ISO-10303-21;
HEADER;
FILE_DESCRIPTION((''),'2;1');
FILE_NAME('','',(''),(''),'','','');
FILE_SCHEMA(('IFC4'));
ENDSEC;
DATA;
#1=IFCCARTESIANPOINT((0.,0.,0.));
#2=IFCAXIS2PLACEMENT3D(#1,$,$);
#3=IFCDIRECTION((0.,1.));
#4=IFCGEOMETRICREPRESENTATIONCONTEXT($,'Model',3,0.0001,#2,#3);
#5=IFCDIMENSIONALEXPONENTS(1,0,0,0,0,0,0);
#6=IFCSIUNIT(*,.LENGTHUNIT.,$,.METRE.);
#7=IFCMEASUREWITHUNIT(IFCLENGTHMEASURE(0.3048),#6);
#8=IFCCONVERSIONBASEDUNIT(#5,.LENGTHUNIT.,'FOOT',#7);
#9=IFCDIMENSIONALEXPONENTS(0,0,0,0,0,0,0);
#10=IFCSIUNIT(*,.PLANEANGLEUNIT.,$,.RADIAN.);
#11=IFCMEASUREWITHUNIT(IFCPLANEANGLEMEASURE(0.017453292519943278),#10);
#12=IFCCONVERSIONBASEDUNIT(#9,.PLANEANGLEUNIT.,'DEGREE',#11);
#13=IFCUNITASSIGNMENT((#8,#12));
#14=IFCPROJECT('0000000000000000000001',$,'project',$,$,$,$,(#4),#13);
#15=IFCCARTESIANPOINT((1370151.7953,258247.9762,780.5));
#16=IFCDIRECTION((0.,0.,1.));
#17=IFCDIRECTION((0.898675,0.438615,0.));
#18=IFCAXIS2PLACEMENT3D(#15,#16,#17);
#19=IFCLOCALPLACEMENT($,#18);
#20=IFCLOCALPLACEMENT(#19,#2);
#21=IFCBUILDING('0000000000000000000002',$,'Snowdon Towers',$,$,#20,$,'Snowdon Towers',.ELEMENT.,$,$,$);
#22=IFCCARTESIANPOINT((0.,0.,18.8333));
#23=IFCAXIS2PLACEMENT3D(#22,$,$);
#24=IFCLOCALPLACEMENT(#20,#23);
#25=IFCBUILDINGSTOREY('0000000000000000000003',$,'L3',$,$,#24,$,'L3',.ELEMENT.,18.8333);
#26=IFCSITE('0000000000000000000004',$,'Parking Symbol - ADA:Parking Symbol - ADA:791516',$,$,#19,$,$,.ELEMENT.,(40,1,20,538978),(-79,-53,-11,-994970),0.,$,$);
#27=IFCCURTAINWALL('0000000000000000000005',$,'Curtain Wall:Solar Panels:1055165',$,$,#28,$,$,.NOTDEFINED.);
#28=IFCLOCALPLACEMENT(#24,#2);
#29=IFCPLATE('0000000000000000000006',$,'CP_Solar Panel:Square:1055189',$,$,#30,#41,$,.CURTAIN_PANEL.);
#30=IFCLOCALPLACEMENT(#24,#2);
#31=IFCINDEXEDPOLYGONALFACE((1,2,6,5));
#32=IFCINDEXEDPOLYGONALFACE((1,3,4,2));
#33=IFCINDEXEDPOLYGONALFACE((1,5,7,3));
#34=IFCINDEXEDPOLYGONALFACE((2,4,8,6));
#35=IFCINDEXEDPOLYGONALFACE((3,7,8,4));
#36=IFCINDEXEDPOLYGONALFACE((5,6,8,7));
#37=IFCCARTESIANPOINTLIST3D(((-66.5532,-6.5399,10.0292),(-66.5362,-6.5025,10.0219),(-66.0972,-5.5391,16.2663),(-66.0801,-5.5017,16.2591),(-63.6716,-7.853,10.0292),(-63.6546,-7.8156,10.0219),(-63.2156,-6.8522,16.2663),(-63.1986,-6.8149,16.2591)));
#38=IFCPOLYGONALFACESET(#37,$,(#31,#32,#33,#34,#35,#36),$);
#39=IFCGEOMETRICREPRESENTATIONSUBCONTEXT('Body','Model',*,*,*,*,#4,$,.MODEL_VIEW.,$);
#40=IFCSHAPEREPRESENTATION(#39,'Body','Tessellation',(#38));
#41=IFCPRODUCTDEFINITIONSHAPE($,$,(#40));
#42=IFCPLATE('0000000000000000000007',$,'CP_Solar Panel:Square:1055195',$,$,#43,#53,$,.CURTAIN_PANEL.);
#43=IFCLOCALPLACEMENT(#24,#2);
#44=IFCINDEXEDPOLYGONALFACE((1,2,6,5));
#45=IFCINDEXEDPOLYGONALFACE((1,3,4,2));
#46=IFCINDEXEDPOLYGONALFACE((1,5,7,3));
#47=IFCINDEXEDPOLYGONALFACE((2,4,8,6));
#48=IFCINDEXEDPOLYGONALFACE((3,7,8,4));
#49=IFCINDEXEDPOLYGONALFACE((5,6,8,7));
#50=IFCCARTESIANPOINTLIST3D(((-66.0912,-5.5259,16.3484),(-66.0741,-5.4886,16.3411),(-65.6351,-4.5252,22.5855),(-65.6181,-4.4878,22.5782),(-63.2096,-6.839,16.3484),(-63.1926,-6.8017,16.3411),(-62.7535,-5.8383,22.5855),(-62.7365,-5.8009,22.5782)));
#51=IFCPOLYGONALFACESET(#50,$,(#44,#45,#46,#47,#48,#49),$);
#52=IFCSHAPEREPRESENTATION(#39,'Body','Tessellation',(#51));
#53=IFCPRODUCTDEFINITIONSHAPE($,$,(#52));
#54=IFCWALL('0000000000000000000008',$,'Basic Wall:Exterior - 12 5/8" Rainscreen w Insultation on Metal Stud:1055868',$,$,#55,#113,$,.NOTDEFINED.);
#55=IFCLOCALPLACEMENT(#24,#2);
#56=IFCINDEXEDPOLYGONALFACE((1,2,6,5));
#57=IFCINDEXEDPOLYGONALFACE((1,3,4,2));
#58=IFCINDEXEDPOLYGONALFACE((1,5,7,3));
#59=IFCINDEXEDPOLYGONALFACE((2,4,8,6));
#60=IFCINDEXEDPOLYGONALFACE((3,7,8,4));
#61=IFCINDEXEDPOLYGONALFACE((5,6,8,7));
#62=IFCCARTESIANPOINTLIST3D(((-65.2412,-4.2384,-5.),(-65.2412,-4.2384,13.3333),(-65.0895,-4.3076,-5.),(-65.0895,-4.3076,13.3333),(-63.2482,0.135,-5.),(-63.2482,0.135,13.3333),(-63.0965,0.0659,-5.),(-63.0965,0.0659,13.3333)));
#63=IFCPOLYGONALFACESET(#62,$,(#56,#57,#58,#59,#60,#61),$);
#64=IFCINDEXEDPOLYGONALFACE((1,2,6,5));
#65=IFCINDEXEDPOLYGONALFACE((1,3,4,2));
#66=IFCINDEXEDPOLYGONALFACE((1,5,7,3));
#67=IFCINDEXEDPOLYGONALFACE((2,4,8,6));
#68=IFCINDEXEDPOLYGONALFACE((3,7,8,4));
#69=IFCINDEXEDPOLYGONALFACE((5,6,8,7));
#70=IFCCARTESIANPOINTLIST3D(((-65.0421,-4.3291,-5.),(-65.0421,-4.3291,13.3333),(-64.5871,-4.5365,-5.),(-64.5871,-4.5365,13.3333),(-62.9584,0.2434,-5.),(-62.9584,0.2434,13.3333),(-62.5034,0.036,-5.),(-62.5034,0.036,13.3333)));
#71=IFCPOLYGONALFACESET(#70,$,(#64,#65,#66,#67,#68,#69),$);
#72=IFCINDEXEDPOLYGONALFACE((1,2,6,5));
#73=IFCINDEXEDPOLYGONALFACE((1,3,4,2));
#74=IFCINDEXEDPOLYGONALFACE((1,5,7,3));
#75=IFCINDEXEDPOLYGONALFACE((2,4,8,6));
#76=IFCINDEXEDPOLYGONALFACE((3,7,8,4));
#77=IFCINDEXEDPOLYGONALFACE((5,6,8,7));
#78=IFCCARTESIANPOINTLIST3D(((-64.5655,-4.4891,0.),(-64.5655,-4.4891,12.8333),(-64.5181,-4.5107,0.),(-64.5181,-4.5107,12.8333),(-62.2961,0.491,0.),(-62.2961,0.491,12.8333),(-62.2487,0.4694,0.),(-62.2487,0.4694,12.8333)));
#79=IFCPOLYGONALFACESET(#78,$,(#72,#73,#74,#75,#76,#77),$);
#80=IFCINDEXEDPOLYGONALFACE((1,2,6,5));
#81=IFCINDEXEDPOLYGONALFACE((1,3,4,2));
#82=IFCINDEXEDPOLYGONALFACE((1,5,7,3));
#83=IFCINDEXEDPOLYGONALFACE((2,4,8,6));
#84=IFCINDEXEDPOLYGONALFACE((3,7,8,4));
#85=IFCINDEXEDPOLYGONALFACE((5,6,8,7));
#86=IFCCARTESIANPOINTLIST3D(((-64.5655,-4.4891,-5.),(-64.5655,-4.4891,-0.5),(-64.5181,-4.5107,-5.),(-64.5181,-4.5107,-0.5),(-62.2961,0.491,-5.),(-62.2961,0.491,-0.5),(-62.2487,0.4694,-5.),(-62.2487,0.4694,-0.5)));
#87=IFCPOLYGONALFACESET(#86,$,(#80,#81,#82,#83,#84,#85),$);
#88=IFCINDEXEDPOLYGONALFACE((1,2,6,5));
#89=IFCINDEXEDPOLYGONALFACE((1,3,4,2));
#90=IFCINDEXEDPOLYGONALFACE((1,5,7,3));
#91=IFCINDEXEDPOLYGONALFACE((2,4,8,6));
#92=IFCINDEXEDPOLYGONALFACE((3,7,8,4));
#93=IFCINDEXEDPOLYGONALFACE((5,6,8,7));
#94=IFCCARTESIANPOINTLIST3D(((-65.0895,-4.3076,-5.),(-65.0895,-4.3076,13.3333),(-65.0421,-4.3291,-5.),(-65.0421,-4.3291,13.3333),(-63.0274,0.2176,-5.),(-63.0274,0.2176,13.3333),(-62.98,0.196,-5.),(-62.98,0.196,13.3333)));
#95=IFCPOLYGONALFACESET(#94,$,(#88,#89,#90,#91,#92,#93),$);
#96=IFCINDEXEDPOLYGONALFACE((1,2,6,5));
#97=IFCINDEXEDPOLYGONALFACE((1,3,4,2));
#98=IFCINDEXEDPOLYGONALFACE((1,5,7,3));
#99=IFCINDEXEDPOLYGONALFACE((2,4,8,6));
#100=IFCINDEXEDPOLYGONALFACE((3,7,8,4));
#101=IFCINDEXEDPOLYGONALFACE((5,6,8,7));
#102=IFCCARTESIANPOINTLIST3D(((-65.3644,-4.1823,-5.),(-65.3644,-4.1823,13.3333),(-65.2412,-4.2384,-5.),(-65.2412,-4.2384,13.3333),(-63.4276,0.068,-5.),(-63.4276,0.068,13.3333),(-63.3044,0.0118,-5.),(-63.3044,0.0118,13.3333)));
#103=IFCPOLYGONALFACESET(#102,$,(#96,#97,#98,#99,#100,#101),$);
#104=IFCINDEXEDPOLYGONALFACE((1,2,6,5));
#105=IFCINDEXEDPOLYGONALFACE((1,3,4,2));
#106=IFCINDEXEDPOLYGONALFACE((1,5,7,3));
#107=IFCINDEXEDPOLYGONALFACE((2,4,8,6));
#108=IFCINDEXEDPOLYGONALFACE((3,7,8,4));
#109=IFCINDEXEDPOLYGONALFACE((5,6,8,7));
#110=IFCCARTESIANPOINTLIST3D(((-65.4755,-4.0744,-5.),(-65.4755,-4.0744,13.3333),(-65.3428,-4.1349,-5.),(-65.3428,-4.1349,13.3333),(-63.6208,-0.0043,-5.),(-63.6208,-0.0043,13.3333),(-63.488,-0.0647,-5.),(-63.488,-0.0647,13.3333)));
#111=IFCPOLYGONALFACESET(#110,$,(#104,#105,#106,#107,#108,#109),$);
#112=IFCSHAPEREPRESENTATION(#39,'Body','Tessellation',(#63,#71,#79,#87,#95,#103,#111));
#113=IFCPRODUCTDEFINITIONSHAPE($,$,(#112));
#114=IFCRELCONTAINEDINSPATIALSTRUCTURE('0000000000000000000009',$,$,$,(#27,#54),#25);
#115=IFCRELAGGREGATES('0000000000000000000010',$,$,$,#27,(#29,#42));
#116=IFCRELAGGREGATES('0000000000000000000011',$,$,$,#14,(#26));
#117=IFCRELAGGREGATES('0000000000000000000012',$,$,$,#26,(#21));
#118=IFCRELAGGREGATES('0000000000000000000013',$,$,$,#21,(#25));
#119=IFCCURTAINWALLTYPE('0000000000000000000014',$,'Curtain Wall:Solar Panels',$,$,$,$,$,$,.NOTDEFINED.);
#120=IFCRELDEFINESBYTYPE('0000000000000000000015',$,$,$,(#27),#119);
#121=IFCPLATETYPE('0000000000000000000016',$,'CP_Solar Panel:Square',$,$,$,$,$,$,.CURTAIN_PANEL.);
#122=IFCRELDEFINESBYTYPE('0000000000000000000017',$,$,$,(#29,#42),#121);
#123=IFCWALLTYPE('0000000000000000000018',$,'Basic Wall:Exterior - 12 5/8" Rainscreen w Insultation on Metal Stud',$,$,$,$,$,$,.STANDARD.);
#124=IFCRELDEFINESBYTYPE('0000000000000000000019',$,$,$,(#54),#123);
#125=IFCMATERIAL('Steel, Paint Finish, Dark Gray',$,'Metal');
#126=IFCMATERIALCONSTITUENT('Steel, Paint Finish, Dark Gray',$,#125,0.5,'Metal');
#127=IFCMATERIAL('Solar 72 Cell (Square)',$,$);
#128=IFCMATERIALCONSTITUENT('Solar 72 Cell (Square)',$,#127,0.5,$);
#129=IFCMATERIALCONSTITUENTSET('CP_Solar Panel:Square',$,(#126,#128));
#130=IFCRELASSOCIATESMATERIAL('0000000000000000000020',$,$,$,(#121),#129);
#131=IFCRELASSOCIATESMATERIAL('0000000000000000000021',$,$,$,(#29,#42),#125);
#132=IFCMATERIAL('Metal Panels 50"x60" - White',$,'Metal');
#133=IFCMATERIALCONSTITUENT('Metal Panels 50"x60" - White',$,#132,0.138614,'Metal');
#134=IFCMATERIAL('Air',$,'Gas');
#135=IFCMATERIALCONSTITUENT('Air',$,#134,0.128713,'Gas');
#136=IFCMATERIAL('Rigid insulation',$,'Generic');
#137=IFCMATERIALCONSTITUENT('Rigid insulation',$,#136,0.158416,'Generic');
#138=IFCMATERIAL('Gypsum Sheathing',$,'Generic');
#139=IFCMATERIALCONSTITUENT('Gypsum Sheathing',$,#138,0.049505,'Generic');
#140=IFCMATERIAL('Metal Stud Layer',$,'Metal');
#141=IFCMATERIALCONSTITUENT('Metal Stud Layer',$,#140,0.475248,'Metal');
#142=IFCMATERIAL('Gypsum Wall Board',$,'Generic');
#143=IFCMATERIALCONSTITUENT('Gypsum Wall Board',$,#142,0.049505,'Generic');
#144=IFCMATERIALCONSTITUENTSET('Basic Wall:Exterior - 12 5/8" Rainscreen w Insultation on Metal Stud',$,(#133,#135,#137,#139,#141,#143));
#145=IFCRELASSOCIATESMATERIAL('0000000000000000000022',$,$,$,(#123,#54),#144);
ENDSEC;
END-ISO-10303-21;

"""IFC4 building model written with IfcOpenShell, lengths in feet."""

from ifc_helpers import new_model, entity, si_unit, converted_unit, direction, frame, origin, place, context, subcontext, project, spatial, indexed_curve, outline, extrude, source, transform, mapped, material, constituent, constituent_set, type_object, type_shapes, element, aggregate, save


model = new_model("IFC4")

# Units and contexts
model_context = context("Model", 3, precision=0.0001, world=origin(), true_north=direction((0.0, 1.0)))
body_context = subcontext(model_context, "Body", "Model", "MODEL_VIEW")
ifc_project = project(units=[converted_unit("LENGTHUNIT", "FOOT", entity("IfcLengthMeasure", 0.3048), si_unit("LENGTHUNIT", "METRE"), dimensions=[1, 0, 0, 0, 0, 0, 0]), converted_unit("PLANEANGLEUNIT", "DEGREE", entity("IfcPlaneAngleMeasure", 0.017453292519943278), si_unit("PLANEANGLEUNIT", "RADIAN"), dimensions=[0, 0, 0, 0, 0, 0, 0])], contexts=[model_context])

# Site, building, storey
site_placement = place(None, frame((1370151.7953, 258247.9762, 780.5), z_axis=(0.0, 0.0, 1.0), x_axis=(0.898675, 0.438615, 0.0)))
site = spatial("IfcSite", under=ifc_project, at=site_placement, Name="Parking Symbol - ADA:Parking Symbol - ADA:791516", CompositionType="ELEMENT", RefLatitude=(40, 1, 20, 538978), RefLongitude=(-79, -53, -11, -994970), RefElevation=0.0)
building_placement = place(site_placement, origin())
building = spatial("IfcBuilding", under=site, at=building_placement, Name="Snowdon Towers", LongName="Snowdon Towers", CompositionType="ELEMENT")
storey_placement = place(building_placement, frame((0.0, 0.0, 18.8333)))
storey = spatial("IfcBuildingStorey", under=building, at=storey_placement, Name="L3", LongName="L3", CompositionType="ELEMENT", Elevation=18.8333)

# Curtain wall
curtain_wall_type_1 = type_object("IfcCurtainWallType", Name="Curtain Wall:Solar Panels", PredefinedType="NOTDEFINED")
curtain_wall_1_placement = place(storey_placement, frame((0.0, 0.0, -18.8333)))
curtain_wall_1 = element("IfcCurtainWall", 1, at=curtain_wall_1_placement, inside=storey, type_object=curtain_wall_type_1, Name="Curtain Wall:Solar Panels:1055165", PredefinedType="NOTDEFINED")
ifc_material_1 = material(Name="Steel, Paint Finish, Dark Gray", Category="Metal")

# Plates
ifc_constituent_1 = constituent(ifc_material_1, Name="Steel, Paint Finish, Dark Gray", Category="Metal", fraction=0.5)
ifc_material_2 = material(Name="Solar 72 Cell (Square)")
ifc_constituent_2 = constituent(ifc_material_2, Name="Solar 72 Cell (Square)", fraction=0.5)
ifc_constituent_set_1 = constituent_set(constituents=[ifc_constituent_1, ifc_constituent_2], Name="CP_Solar Panel:Square")
plate_type_1 = type_object("IfcPlateType", Name="CP_Solar Panel:Square", PredefinedType="CURTAIN_PANEL", material=ifc_constituent_set_1)
shared_shape_1 = source(origin(), body_context, "Body", "SweptSolid", [
    extrude(outline(indexed_curve([(-1.5833, -0.0208), (1.5833, -0.0208), (1.5833, 0.0208), (-1.5833, 0.0208), (-1.5833, -0.0208)], self_intersect=False)), frame((0.0, -0.0417, 0.0)), (0.0, 0.0, 1.0), 6.3333),
])
type_shapes(plate_type_1, [shared_shape_1])
plate_1_placement = place(curtain_wall_1_placement, frame((-65.0869, -7.1404, 28.8517), z_axis=(0.072007, 0.158015, 0.984808), x_axis=(0.909972, -0.414671, 0.0)))
plate_1 = element("IfcPlate", 2, at=plate_1_placement, type_object=plate_type_1, material=ifc_material_1, Name="CP_Solar Panel:Square:1055189", PredefinedType="CURTAIN_PANEL", context=body_context, shape_type="MappedRepresentation", body=[
    mapped(shared_shape_1, transform((0.0, 0.0, 0.0), scale=1.0)),
])
plate_2_placement = place(curtain_wall_1_placement, frame((-64.6248, -6.1265, 35.1708), z_axis=(0.072007, 0.158015, 0.984808), x_axis=(0.909972, -0.414671, 0.0)))
plate_2 = element("IfcPlate", 3, at=plate_2_placement, type_object=plate_type_1, material=ifc_material_1, Name="CP_Solar Panel:Square:1055195", PredefinedType="CURTAIN_PANEL", context=body_context, shape_type="MappedRepresentation", body=[
    mapped(shared_shape_1, transform((0.0, 0.0, 0.0), scale=1.0)),
])
aggregate(curtain_wall_1, [plate_1, plate_2])

# Wall
ifc_material_3 = material(Name="Metal Panels 50\"x60\" - White", Category="Metal")
ifc_constituent_3 = constituent(ifc_material_3, Name="Metal Panels 50\"x60\" - White", Category="Metal", fraction=0.138614)
ifc_material_4 = material(Name="Air", Category="Gas")
ifc_constituent_4 = constituent(ifc_material_4, Name="Air", Category="Gas", fraction=0.128713)
ifc_material_5 = material(Name="Rigid insulation", Category="Generic")
ifc_constituent_5 = constituent(ifc_material_5, Name="Rigid insulation", Category="Generic", fraction=0.158416)
ifc_material_6 = material(Name="Gypsum Sheathing", Category="Generic")
ifc_constituent_6 = constituent(ifc_material_6, Name="Gypsum Sheathing", Category="Generic", fraction=0.049505)
ifc_material_7 = material(Name="Metal Stud Layer", Category="Metal")
ifc_constituent_7 = constituent(ifc_material_7, Name="Metal Stud Layer", Category="Metal", fraction=0.475248)
ifc_material_8 = material(Name="Gypsum Wall Board", Category="Generic")
ifc_constituent_8 = constituent(ifc_material_8, Name="Gypsum Wall Board", Category="Generic", fraction=0.049505)
ifc_constituent_set_2 = constituent_set(constituents=[ifc_constituent_3, ifc_constituent_4, ifc_constituent_5, ifc_constituent_6, ifc_constituent_7, ifc_constituent_8], Name="Basic Wall:Exterior - 12 5/8\" Rainscreen w Insultation on Metal Stud")
wall_type = type_object("IfcWallType", Name="Basic Wall:Exterior - 12 5/8\" Rainscreen w Insultation on Metal Stud", PredefinedType="STANDARD", material=ifc_constituent_set_2)
wall_placement = place(storey_placement, frame((-64.9968, -4.2926, -5.0), z_axis=(0.0, 0.0, 1.0), x_axis=(0.414671, 0.909972, 0.0)))
element("IfcWall", 4, at=wall_placement, inside=storey, type_object=wall_type, material=ifc_constituent_set_2, Name="Basic Wall:Exterior - 12 5/8\" Rainscreen w Insultation on Metal Stud:1055868", PredefinedType="NOTDEFINED", context=body_context, shape_type="SweptSolid", body=[
    extrude(outline(indexed_curve([(-9.1667, -0.0833), (9.1667, -0.0833), (9.1667, 0.0833), (-9.1667, 0.0833), (-9.1667, -0.0833)], self_intersect=False)), frame((-0.0521, 0.1615, 9.1667), z_axis=(1.0, 0.0, 0.0), x_axis=(0.0, 0.0, -1.0)), (0.0, 0.0, 1.0), 4.8062),
    extrude(outline(indexed_curve([(-2.5125, -0.25), (2.5125, -0.25), (2.5125, 0.25), (-2.5125, 0.25), (-2.5125, -0.25)], self_intersect=False)), frame((2.4604, -0.224, 0.0)), (0.0, 0.0, 1.0), 18.3333),
    extrude(outline(indexed_curve([(-0.026, -2.7364), (0.026, -2.7364), (0.026, 2.7364), (-0.026, 2.7364), (-0.026, -2.7364)], self_intersect=False)), frame((2.7364, -0.5, 5.0), z_axis=(0.0, 0.0, 1.0), x_axis=(0.0, 1.0, 0.0)), (0.0, 0.0, 1.0), 12.8333),
    extrude(outline(indexed_curve([(-0.026, -2.25), (0.026, -2.25), (0.026, 2.25), (-0.026, 2.25), (-0.026, -2.25)], self_intersect=False)), frame((0.0, -0.5, 2.25), z_axis=(1.0, 0.0, 0.0), x_axis=(0.0, 1.0, 0.0)), (0.0, 0.0, 1.0), 5.4728),
    extrude(outline(indexed_curve([(-2.4864, -0.026), (2.4864, -0.026), (2.4864, 0.026), (-2.4864, 0.026), (-2.4864, -0.026)], self_intersect=False)), frame((2.4343, 0.0521, 0.0)), (0.0, 0.0, 1.0), 18.3333),
    extrude(outline(indexed_curve([(-9.1667, -0.0677), (9.1667, -0.0677), (9.1667, 0.0677), (-9.1667, 0.0677), (-9.1667, -0.0677)], self_intersect=False)), frame((-0.0521, 0.3125, 9.1667), z_axis=(1.0, 0.0, 0.0), x_axis=(0.0, 0.0, -1.0)), (0.0, 0.0, 1.0), 4.6707),
    extrude(outline(indexed_curve([(-0.0729, -9.1667), (0.0729, -9.1667), (0.0729, 9.1667), (-0.0729, 9.1667), (-0.0729, -9.1667)], self_intersect=False)), frame((0.0, 0.4531, 9.1667), z_axis=(1.0, 0.0, 0.0), x_axis=(0.0, -1.0, 0.0)), (0.0, 0.0, 1.0), 4.4728),
])

save(model, "model.ifc")
